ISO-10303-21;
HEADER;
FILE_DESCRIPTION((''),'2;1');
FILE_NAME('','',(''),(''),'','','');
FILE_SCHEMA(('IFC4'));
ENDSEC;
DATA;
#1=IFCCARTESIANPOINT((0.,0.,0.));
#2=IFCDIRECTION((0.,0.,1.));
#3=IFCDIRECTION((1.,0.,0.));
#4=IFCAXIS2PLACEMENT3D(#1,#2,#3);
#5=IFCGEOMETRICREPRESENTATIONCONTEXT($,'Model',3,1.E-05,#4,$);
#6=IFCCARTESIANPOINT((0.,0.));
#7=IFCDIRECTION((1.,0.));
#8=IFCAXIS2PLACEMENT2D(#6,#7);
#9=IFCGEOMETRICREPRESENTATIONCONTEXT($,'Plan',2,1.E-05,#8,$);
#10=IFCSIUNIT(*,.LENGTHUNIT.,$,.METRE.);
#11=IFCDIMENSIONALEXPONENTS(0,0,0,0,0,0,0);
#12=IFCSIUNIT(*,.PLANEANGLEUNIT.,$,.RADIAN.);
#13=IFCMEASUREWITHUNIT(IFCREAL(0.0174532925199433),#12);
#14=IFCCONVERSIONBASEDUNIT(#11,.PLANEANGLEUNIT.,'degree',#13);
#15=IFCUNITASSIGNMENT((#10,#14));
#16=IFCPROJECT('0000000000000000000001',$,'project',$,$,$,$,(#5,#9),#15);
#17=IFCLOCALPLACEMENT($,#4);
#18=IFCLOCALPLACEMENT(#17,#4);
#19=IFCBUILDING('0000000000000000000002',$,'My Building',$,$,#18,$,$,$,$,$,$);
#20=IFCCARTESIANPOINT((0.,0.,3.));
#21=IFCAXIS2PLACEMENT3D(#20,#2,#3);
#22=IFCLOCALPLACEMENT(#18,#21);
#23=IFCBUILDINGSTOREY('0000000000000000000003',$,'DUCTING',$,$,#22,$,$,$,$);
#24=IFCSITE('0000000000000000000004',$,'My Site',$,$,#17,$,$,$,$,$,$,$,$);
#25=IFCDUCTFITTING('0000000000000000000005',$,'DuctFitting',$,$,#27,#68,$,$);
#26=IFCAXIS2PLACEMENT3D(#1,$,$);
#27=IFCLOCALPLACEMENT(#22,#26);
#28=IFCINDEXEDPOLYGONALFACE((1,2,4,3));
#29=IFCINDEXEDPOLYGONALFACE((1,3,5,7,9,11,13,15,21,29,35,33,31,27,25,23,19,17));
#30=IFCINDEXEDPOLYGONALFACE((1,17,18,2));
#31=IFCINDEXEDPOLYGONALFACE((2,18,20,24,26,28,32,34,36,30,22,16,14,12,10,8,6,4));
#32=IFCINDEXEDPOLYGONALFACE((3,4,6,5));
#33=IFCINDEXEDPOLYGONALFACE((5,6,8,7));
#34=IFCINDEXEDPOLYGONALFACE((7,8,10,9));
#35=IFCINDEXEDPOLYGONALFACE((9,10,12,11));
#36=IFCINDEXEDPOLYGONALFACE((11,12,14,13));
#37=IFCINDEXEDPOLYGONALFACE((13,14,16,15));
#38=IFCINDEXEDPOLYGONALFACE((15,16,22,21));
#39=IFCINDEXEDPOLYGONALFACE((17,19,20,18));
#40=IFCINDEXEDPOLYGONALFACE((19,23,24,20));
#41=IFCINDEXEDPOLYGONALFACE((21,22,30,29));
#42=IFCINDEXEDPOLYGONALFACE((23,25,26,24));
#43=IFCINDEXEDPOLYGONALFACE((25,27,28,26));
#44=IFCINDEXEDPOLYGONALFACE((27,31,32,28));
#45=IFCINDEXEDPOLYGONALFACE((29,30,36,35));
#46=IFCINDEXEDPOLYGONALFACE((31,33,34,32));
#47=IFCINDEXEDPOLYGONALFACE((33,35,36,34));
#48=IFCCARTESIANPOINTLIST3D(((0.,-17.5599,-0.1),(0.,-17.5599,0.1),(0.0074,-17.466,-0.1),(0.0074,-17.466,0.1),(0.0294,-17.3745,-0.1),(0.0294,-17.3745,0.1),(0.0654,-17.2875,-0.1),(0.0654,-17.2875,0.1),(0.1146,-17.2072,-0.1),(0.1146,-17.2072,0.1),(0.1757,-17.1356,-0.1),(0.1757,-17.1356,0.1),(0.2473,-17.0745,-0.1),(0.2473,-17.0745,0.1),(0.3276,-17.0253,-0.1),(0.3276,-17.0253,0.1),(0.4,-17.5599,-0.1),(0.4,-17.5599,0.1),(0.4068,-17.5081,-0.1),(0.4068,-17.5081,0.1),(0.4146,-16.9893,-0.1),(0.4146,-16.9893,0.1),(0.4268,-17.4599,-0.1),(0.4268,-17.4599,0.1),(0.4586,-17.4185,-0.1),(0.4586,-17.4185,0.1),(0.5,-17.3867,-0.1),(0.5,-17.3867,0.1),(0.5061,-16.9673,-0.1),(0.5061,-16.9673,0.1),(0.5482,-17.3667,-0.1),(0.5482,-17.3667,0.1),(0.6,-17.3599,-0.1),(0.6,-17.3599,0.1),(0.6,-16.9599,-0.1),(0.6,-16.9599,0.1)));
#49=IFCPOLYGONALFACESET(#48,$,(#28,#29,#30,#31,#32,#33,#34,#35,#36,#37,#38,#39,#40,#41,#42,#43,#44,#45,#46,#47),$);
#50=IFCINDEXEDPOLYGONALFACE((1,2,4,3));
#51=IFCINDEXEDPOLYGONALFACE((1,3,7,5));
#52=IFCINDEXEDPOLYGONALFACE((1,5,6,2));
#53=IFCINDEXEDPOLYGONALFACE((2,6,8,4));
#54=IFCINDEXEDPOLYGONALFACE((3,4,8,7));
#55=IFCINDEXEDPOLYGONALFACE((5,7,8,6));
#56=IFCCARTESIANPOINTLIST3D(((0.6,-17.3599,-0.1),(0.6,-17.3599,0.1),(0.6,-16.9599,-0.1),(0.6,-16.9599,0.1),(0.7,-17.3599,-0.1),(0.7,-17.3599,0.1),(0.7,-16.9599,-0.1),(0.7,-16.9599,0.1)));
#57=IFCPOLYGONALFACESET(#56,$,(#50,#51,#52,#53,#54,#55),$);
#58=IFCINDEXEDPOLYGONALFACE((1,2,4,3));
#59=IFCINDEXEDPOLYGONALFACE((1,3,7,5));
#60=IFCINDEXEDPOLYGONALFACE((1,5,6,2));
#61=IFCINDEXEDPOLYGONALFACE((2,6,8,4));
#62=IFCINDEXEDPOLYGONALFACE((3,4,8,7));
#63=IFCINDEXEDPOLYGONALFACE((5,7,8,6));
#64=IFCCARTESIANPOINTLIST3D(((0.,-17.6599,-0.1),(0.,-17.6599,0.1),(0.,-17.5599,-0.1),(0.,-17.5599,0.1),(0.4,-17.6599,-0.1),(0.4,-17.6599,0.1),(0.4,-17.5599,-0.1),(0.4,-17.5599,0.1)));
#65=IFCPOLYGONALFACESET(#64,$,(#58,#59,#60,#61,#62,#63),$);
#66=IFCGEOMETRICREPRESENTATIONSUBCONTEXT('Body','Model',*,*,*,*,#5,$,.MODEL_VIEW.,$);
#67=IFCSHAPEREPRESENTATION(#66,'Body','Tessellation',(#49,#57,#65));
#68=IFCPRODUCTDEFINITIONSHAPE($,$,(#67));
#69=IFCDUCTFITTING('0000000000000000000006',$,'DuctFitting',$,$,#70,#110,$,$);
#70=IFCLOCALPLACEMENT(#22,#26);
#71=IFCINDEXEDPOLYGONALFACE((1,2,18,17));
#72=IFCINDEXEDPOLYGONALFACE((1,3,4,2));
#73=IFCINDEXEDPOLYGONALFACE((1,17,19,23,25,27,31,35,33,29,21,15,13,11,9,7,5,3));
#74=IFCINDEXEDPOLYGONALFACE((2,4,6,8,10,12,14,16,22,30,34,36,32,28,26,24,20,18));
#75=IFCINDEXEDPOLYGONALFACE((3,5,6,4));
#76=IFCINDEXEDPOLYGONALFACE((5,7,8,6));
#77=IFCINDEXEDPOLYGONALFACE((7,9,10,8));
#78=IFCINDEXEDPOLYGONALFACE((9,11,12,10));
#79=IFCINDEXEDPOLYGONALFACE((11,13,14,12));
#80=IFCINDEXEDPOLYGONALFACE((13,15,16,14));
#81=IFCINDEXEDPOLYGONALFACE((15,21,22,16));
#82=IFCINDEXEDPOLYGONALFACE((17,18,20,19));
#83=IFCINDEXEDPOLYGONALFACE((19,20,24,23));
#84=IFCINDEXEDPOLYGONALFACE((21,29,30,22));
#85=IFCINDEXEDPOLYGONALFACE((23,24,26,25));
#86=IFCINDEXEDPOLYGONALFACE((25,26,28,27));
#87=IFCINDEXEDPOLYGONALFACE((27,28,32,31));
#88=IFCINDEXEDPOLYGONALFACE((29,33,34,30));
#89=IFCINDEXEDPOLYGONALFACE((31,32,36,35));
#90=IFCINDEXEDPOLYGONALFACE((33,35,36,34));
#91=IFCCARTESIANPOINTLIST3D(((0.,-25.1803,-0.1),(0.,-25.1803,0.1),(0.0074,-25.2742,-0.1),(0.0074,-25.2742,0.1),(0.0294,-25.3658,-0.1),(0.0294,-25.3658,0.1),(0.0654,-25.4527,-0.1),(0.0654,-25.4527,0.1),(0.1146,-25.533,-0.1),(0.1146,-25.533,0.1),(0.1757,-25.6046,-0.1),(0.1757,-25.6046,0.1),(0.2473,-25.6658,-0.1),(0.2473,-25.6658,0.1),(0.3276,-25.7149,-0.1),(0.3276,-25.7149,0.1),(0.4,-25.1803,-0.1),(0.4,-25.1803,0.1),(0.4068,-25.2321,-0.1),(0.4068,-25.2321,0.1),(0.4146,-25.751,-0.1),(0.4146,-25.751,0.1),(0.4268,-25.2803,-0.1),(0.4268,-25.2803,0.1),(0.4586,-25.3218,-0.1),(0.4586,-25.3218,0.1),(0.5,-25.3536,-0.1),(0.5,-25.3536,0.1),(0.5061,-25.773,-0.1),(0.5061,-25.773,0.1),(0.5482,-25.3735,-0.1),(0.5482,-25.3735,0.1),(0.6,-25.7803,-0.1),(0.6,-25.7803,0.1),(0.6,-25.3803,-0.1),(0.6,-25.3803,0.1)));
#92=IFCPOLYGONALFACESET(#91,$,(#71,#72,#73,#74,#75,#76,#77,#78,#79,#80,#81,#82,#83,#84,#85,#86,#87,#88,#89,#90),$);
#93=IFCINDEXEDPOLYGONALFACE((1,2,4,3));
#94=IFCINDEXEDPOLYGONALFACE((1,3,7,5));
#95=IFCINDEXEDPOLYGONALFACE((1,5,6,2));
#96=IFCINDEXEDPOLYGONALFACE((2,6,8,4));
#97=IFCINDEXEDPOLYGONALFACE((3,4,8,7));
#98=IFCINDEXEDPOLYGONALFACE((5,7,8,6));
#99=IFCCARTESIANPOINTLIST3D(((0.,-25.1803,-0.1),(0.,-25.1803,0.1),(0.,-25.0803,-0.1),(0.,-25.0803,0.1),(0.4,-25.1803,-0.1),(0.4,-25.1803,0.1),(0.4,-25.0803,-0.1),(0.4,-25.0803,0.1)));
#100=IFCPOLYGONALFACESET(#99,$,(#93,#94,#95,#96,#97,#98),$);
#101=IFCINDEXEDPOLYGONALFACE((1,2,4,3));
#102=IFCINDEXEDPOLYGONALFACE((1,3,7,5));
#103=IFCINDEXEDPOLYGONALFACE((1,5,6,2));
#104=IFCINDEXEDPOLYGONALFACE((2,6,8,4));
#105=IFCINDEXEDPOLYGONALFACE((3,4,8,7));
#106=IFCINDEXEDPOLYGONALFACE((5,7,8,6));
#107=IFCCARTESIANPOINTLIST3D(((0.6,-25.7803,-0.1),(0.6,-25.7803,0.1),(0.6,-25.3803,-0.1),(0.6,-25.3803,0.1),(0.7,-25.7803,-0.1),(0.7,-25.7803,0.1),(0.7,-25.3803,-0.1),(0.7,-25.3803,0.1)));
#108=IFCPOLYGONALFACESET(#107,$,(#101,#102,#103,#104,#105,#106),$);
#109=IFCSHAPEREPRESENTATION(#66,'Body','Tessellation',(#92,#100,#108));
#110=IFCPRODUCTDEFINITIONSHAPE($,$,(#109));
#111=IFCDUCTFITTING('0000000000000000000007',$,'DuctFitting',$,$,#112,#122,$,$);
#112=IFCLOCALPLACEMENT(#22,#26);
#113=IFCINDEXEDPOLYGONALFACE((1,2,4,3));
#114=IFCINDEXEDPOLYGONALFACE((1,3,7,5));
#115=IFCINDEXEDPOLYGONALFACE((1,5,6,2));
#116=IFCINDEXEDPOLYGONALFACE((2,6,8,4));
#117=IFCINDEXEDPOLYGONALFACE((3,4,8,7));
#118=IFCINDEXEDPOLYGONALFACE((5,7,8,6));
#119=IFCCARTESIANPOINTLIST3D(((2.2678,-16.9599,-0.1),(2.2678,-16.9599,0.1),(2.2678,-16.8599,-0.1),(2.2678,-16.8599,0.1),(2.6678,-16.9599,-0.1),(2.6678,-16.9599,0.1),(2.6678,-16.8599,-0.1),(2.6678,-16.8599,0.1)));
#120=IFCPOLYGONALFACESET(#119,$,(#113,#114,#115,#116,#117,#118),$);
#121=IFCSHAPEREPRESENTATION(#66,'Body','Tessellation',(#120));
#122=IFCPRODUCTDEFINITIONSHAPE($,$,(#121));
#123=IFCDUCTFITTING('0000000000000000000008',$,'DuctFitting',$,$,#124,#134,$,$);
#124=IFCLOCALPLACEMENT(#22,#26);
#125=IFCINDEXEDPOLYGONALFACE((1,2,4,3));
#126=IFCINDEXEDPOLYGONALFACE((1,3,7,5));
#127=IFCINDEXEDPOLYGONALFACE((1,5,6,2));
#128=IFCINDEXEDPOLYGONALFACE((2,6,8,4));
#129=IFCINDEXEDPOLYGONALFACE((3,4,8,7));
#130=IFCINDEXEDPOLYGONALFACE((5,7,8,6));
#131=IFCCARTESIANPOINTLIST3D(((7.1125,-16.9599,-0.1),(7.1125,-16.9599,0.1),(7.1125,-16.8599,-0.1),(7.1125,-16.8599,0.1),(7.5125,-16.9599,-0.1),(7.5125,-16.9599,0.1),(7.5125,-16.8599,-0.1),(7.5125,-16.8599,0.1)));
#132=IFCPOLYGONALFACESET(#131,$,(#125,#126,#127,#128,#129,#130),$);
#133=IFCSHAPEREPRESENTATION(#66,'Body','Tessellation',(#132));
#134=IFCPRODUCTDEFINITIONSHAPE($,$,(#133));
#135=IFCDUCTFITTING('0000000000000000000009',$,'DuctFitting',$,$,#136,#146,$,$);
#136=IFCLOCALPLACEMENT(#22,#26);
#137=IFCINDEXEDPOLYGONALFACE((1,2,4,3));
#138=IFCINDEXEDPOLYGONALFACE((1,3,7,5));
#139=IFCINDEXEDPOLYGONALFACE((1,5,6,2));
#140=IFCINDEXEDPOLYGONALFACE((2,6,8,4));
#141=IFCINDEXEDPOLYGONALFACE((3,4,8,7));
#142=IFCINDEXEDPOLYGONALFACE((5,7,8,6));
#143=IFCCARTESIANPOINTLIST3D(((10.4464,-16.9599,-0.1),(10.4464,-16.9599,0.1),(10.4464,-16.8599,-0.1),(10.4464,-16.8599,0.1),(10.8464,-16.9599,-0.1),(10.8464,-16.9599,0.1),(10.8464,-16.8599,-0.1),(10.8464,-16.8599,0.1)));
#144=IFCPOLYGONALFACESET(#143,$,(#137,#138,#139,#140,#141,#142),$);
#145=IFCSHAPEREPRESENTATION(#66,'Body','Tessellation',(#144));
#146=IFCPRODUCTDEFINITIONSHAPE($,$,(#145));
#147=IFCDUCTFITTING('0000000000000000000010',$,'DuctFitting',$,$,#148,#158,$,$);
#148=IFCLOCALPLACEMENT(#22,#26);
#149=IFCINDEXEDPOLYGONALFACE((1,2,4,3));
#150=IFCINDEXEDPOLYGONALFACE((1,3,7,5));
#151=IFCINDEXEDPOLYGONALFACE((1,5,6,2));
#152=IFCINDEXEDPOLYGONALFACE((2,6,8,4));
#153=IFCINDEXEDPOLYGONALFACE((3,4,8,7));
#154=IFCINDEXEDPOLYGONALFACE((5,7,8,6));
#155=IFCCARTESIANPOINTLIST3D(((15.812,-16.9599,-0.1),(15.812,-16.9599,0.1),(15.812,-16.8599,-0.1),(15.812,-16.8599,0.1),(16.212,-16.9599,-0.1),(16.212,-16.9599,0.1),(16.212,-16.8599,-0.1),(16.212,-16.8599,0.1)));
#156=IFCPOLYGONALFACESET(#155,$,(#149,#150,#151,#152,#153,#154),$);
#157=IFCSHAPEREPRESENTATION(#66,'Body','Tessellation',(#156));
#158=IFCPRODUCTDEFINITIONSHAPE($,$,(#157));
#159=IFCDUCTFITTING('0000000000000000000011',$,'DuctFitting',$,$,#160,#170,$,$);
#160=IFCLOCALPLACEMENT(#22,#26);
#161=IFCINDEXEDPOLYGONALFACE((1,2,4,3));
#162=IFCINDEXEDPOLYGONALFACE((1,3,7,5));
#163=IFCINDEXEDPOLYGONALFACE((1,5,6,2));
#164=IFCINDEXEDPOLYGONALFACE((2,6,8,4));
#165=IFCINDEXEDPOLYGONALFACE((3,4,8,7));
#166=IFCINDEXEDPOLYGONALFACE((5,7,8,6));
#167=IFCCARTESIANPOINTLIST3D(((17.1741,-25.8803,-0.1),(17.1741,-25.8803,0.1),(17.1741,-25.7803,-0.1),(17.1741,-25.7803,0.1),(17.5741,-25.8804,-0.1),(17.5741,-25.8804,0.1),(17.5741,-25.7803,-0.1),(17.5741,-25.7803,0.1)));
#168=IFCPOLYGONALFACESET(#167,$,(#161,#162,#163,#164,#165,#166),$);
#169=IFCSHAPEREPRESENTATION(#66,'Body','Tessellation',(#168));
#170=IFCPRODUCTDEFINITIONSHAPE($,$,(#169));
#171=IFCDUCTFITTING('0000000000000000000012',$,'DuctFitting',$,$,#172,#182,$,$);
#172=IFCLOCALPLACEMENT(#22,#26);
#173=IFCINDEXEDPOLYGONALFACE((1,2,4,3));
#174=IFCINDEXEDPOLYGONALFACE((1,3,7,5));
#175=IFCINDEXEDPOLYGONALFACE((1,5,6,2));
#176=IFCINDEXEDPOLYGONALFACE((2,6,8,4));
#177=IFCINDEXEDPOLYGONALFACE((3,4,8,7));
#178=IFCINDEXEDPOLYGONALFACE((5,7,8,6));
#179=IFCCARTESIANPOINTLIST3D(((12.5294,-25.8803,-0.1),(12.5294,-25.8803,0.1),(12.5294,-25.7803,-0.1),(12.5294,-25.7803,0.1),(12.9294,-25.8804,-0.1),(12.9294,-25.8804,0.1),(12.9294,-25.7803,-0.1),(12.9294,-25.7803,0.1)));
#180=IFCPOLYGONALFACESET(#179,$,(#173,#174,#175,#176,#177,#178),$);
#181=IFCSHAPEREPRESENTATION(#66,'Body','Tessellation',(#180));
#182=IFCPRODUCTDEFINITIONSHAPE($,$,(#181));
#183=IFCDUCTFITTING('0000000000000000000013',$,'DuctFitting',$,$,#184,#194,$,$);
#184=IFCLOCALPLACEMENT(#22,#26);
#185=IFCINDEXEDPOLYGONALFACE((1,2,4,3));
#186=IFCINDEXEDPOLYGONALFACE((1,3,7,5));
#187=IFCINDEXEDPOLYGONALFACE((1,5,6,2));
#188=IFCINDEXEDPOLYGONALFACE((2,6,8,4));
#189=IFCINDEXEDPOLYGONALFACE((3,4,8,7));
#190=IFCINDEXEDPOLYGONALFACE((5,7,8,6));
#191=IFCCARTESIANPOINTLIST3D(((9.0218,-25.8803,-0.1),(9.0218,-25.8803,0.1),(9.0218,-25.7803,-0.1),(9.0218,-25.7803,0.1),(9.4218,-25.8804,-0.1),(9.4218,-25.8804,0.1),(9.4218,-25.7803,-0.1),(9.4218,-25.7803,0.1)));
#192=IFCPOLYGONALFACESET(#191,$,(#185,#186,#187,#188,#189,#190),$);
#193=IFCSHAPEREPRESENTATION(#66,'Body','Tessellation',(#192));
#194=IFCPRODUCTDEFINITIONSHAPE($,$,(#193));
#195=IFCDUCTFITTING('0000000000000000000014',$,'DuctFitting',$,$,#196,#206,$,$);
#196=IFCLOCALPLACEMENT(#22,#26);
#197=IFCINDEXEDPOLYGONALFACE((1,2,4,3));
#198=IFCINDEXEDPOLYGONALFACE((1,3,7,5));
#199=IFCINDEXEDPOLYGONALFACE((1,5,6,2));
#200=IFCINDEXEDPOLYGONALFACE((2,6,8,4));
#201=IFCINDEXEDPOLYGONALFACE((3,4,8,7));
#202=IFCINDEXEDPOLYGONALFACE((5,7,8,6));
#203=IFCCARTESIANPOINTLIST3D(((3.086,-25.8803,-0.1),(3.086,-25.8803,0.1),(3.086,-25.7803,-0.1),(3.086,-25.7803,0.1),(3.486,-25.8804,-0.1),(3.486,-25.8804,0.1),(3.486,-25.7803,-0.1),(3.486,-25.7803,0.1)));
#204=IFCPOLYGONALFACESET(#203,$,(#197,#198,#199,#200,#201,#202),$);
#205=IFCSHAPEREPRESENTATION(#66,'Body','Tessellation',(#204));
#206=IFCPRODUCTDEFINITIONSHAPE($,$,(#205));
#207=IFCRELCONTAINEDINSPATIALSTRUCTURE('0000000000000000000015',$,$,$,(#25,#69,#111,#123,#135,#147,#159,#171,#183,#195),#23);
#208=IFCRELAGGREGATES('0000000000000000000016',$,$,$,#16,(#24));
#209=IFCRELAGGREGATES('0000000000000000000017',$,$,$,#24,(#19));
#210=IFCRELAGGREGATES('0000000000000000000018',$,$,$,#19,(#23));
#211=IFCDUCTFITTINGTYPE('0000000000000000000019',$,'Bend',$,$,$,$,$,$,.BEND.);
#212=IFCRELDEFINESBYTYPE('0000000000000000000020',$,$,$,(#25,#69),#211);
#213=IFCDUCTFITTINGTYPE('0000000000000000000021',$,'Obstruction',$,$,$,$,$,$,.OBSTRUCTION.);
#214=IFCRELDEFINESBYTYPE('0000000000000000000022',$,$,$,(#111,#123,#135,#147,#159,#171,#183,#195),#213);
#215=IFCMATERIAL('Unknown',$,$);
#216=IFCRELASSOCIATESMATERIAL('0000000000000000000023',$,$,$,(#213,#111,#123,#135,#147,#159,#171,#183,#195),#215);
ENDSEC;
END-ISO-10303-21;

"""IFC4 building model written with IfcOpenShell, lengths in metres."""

from ifc_helpers import new_model, entity, si_unit, converted_unit, frame, origin_with_axes, origin_2d_with_axis, place, context, subcontext, project, spatial, line, arc, indexed_curve, rectangle, outline, extrude, source, transform, mapped, material, material_profile, profile_set, profile_usage, type_object, type_shapes, element, save


model = new_model("IFC4")

# Units and contexts
model_context = context("Model", 3, precision=1e-05, world=origin_with_axes())
plan_context = context("Plan", 2, precision=1e-05, world=origin_2d_with_axis())
body_context = subcontext(model_context, "Body", "Model", "MODEL_VIEW")
ifc_project = project(units=[si_unit("LENGTHUNIT", "METRE"), converted_unit("PLANEANGLEUNIT", "degree", entity("IfcReal", 0.0174532925199433), si_unit("PLANEANGLEUNIT", "RADIAN"), dimensions=[0, 0, 0, 0, 0, 0, 0])], contexts=[model_context, plan_context])

# Site, building, storey
site_placement = place(None, origin_with_axes())
site = spatial("IfcSite", under=ifc_project, at=site_placement, Name="My Site")
building_placement = place(site_placement, origin_with_axes())
building = spatial("IfcBuilding", under=site, at=building_placement, Name="My Building")
storey_placement = place(building_placement, frame((0.0, 0.0, 3.0), z_axis=(0.0, 0.0, 1.0), x_axis=(1.0, 0.0, 0.0)))
storey = spatial("IfcBuildingStorey", under=building, at=storey_placement, Name="DUCTING")

# Shared definitions
ifc_material = material(Name="Unknown")

# Duct fittings
duct_fitting_type_1 = type_object("IfcDuctFittingType", Name="Bend", PredefinedType="BEND")
shared_shape = source(origin_with_axes(), body_context, "Body", "SweptSolid", [
    extrude(outline(indexed_curve([(0.2, 0.0), (0.2586, 0.1414), (0.4, 0.2), (0.4, 0.6), (-0.0243, 0.4243), (-0.2, 0.0)], segments=[arc(1, 2, 3), line(3, 4), arc(4, 5, 6), line(6, 1)])), frame((0.0, -0.1, 0.1), z_axis=(0.0, -1.0, 0.0), x_axis=(1.0, 0.0, 0.0)), (0.0, 0.0, -1.0), 0.2),
    extrude(rectangle(XDim=0.4, YDim=0.2), origin_with_axes(), (0.0, 0.0, 1.0), 0.1),
    extrude(rectangle(XDim=0.4, YDim=0.2), frame((0.4, 0.0, 0.5), z_axis=(1.0, 0.0, 0.0), x_axis=(0.0, 0.0, 1.0)), (0.0, 0.0, 1.0), 0.1),
])
type_shapes(duct_fitting_type_1, [shared_shape])
for number, where, z_axis, x_axis, name in (
    (1, (0.7, -17.1599, 0.0), (-1.0, 0.0, 0.0), (0.0, -1.0, 0.0), "DuctFitting"),
    (2, (0.2, -25.0803, 0.0), (0.0, -1.0, 0.0), (1.0, 0.0, 0.0), "DuctFitting"),
):
    element("IfcDuctFitting", number, at=place(storey_placement, frame(where, z_axis=z_axis, x_axis=x_axis)), inside=storey, type_object=duct_fitting_type_1, Name=name, context=body_context, shape_type="MappedRepresentation", body=[
        mapped(shared_shape, transform((0.0, 0.0, 0.0), x_axis=(1.0, 0.0, 0.0), y_axis=(0.0, 1.0, 0.0), z_axis=(0.0, 0.0, 1.0), scale=1.0)),
    ])
ifc_material_profile_1 = material_profile(ifc_material, rectangle(XDim=0.4, YDim=0.2))
ifc_profile_set_1 = profile_set([ifc_material_profile_1])
ifc_profile_usage_1 = profile_usage(ifc_profile_set_1, cardinal=5)
duct_fitting_type_2 = type_object("IfcDuctFittingType", Name="Obstruction", PredefinedType="OBSTRUCTION", material=ifc_profile_set_1)
duct_fitting_1_placement = place(storey_placement, frame((2.4678, -16.8599, 0.0), z_axis=(0.0, -1.0, 0.0), x_axis=(1.0, 0.0, 0.0)))
element("IfcDuctFitting", 3, at=duct_fitting_1_placement, inside=storey, type_object=duct_fitting_type_2, material=ifc_profile_usage_1, Name="DuctFitting", context=body_context, shape_type="SweptSolid", body=[
    extrude(rectangle(XDim=0.4, YDim=0.2), origin_with_axes(), (0.0, 0.0, 1.0), 0.1),
])
ifc_profile_usage_2 = profile_usage(ifc_profile_set_1, cardinal=5)
duct_fitting_2_placement = place(storey_placement, frame((7.3125, -16.8599, 0.0), z_axis=(0.0, -1.0, 0.0), x_axis=(1.0, 0.0, 0.0)))
element("IfcDuctFitting", 4, at=duct_fitting_2_placement, inside=storey, type_object=duct_fitting_type_2, material=ifc_profile_usage_2, Name="DuctFitting", context=body_context, shape_type="SweptSolid", body=[
    extrude(rectangle(XDim=0.4, YDim=0.2), origin_with_axes(), (0.0, 0.0, 1.0), 0.1),
])
ifc_profile_usage_3 = profile_usage(ifc_profile_set_1, cardinal=5)
duct_fitting_3_placement = place(storey_placement, frame((10.6464, -16.8599, 0.0), z_axis=(0.0, -1.0, 0.0), x_axis=(1.0, 0.0, 0.0)))
element("IfcDuctFitting", 5, at=duct_fitting_3_placement, inside=storey, type_object=duct_fitting_type_2, material=ifc_profile_usage_3, Name="DuctFitting", context=body_context, shape_type="SweptSolid", body=[
    extrude(rectangle(XDim=0.4, YDim=0.2), origin_with_axes(), (0.0, 0.0, 1.0), 0.1),
])
ifc_profile_usage_4 = profile_usage(ifc_profile_set_1, cardinal=5)
duct_fitting_4_placement = place(storey_placement, frame((16.012, -16.8599, 0.0), z_axis=(0.0, -1.0, 0.0), x_axis=(1.0, 0.0, 0.0)))
element("IfcDuctFitting", 6, at=duct_fitting_4_placement, inside=storey, type_object=duct_fitting_type_2, material=ifc_profile_usage_4, Name="DuctFitting", context=body_context, shape_type="SweptSolid", body=[
    extrude(rectangle(XDim=0.4, YDim=0.2), origin_with_axes(), (0.0, 0.0, 1.0), 0.1),
])
ifc_profile_usage_5 = profile_usage(ifc_profile_set_1, cardinal=5)
duct_fitting_5_placement = place(storey_placement, frame((17.3741, -25.8804, 0.0), z_axis=(0.000001, 1.0, 0.0), x_axis=(-1.0, 0.000001, 0.0)))
element("IfcDuctFitting", 7, at=duct_fitting_5_placement, inside=storey, type_object=duct_fitting_type_2, material=ifc_profile_usage_5, Name="DuctFitting", context=body_context, shape_type="SweptSolid", body=[
    extrude(rectangle(XDim=0.4, YDim=0.2), origin_with_axes(), (0.0, 0.0, 1.0), 0.1),
])
ifc_profile_usage_6 = profile_usage(ifc_profile_set_1, cardinal=5)
duct_fitting_6_placement = place(storey_placement, frame((12.7294, -25.8804, 0.0), z_axis=(0.000001, 1.0, 0.0), x_axis=(-1.0, 0.000001, 0.0)))
element("IfcDuctFitting", 8, at=duct_fitting_6_placement, inside=storey, type_object=duct_fitting_type_2, material=ifc_profile_usage_6, Name="DuctFitting", context=body_context, shape_type="SweptSolid", body=[
    extrude(rectangle(XDim=0.4, YDim=0.2), origin_with_axes(), (0.0, 0.0, 1.0), 0.1),
])
ifc_profile_usage_7 = profile_usage(ifc_profile_set_1, cardinal=5)
duct_fitting_7_placement = place(storey_placement, frame((9.2218, -25.8804, 0.0), z_axis=(0.000001, 1.0, 0.0), x_axis=(-1.0, 0.000001, 0.0)))
element("IfcDuctFitting", 9, at=duct_fitting_7_placement, inside=storey, type_object=duct_fitting_type_2, material=ifc_profile_usage_7, Name="DuctFitting", context=body_context, shape_type="SweptSolid", body=[
    extrude(rectangle(XDim=0.4, YDim=0.2), origin_with_axes(), (0.0, 0.0, 1.0), 0.1),
])
ifc_profile_usage_8 = profile_usage(ifc_profile_set_1, cardinal=5)
duct_fitting_8_placement = place(storey_placement, frame((3.286, -25.8804, 0.0), z_axis=(0.000001, 1.0, 0.0), x_axis=(-1.0, 0.000001, 0.0)))
element("IfcDuctFitting", 10, at=duct_fitting_8_placement, inside=storey, type_object=duct_fitting_type_2, material=ifc_profile_usage_8, Name="DuctFitting", context=body_context, shape_type="SweptSolid", body=[
    extrude(rectangle(XDim=0.4, YDim=0.2), origin_with_axes(), (0.0, 0.0, 1.0), 0.1),
])

save(model, "model.ifc")
